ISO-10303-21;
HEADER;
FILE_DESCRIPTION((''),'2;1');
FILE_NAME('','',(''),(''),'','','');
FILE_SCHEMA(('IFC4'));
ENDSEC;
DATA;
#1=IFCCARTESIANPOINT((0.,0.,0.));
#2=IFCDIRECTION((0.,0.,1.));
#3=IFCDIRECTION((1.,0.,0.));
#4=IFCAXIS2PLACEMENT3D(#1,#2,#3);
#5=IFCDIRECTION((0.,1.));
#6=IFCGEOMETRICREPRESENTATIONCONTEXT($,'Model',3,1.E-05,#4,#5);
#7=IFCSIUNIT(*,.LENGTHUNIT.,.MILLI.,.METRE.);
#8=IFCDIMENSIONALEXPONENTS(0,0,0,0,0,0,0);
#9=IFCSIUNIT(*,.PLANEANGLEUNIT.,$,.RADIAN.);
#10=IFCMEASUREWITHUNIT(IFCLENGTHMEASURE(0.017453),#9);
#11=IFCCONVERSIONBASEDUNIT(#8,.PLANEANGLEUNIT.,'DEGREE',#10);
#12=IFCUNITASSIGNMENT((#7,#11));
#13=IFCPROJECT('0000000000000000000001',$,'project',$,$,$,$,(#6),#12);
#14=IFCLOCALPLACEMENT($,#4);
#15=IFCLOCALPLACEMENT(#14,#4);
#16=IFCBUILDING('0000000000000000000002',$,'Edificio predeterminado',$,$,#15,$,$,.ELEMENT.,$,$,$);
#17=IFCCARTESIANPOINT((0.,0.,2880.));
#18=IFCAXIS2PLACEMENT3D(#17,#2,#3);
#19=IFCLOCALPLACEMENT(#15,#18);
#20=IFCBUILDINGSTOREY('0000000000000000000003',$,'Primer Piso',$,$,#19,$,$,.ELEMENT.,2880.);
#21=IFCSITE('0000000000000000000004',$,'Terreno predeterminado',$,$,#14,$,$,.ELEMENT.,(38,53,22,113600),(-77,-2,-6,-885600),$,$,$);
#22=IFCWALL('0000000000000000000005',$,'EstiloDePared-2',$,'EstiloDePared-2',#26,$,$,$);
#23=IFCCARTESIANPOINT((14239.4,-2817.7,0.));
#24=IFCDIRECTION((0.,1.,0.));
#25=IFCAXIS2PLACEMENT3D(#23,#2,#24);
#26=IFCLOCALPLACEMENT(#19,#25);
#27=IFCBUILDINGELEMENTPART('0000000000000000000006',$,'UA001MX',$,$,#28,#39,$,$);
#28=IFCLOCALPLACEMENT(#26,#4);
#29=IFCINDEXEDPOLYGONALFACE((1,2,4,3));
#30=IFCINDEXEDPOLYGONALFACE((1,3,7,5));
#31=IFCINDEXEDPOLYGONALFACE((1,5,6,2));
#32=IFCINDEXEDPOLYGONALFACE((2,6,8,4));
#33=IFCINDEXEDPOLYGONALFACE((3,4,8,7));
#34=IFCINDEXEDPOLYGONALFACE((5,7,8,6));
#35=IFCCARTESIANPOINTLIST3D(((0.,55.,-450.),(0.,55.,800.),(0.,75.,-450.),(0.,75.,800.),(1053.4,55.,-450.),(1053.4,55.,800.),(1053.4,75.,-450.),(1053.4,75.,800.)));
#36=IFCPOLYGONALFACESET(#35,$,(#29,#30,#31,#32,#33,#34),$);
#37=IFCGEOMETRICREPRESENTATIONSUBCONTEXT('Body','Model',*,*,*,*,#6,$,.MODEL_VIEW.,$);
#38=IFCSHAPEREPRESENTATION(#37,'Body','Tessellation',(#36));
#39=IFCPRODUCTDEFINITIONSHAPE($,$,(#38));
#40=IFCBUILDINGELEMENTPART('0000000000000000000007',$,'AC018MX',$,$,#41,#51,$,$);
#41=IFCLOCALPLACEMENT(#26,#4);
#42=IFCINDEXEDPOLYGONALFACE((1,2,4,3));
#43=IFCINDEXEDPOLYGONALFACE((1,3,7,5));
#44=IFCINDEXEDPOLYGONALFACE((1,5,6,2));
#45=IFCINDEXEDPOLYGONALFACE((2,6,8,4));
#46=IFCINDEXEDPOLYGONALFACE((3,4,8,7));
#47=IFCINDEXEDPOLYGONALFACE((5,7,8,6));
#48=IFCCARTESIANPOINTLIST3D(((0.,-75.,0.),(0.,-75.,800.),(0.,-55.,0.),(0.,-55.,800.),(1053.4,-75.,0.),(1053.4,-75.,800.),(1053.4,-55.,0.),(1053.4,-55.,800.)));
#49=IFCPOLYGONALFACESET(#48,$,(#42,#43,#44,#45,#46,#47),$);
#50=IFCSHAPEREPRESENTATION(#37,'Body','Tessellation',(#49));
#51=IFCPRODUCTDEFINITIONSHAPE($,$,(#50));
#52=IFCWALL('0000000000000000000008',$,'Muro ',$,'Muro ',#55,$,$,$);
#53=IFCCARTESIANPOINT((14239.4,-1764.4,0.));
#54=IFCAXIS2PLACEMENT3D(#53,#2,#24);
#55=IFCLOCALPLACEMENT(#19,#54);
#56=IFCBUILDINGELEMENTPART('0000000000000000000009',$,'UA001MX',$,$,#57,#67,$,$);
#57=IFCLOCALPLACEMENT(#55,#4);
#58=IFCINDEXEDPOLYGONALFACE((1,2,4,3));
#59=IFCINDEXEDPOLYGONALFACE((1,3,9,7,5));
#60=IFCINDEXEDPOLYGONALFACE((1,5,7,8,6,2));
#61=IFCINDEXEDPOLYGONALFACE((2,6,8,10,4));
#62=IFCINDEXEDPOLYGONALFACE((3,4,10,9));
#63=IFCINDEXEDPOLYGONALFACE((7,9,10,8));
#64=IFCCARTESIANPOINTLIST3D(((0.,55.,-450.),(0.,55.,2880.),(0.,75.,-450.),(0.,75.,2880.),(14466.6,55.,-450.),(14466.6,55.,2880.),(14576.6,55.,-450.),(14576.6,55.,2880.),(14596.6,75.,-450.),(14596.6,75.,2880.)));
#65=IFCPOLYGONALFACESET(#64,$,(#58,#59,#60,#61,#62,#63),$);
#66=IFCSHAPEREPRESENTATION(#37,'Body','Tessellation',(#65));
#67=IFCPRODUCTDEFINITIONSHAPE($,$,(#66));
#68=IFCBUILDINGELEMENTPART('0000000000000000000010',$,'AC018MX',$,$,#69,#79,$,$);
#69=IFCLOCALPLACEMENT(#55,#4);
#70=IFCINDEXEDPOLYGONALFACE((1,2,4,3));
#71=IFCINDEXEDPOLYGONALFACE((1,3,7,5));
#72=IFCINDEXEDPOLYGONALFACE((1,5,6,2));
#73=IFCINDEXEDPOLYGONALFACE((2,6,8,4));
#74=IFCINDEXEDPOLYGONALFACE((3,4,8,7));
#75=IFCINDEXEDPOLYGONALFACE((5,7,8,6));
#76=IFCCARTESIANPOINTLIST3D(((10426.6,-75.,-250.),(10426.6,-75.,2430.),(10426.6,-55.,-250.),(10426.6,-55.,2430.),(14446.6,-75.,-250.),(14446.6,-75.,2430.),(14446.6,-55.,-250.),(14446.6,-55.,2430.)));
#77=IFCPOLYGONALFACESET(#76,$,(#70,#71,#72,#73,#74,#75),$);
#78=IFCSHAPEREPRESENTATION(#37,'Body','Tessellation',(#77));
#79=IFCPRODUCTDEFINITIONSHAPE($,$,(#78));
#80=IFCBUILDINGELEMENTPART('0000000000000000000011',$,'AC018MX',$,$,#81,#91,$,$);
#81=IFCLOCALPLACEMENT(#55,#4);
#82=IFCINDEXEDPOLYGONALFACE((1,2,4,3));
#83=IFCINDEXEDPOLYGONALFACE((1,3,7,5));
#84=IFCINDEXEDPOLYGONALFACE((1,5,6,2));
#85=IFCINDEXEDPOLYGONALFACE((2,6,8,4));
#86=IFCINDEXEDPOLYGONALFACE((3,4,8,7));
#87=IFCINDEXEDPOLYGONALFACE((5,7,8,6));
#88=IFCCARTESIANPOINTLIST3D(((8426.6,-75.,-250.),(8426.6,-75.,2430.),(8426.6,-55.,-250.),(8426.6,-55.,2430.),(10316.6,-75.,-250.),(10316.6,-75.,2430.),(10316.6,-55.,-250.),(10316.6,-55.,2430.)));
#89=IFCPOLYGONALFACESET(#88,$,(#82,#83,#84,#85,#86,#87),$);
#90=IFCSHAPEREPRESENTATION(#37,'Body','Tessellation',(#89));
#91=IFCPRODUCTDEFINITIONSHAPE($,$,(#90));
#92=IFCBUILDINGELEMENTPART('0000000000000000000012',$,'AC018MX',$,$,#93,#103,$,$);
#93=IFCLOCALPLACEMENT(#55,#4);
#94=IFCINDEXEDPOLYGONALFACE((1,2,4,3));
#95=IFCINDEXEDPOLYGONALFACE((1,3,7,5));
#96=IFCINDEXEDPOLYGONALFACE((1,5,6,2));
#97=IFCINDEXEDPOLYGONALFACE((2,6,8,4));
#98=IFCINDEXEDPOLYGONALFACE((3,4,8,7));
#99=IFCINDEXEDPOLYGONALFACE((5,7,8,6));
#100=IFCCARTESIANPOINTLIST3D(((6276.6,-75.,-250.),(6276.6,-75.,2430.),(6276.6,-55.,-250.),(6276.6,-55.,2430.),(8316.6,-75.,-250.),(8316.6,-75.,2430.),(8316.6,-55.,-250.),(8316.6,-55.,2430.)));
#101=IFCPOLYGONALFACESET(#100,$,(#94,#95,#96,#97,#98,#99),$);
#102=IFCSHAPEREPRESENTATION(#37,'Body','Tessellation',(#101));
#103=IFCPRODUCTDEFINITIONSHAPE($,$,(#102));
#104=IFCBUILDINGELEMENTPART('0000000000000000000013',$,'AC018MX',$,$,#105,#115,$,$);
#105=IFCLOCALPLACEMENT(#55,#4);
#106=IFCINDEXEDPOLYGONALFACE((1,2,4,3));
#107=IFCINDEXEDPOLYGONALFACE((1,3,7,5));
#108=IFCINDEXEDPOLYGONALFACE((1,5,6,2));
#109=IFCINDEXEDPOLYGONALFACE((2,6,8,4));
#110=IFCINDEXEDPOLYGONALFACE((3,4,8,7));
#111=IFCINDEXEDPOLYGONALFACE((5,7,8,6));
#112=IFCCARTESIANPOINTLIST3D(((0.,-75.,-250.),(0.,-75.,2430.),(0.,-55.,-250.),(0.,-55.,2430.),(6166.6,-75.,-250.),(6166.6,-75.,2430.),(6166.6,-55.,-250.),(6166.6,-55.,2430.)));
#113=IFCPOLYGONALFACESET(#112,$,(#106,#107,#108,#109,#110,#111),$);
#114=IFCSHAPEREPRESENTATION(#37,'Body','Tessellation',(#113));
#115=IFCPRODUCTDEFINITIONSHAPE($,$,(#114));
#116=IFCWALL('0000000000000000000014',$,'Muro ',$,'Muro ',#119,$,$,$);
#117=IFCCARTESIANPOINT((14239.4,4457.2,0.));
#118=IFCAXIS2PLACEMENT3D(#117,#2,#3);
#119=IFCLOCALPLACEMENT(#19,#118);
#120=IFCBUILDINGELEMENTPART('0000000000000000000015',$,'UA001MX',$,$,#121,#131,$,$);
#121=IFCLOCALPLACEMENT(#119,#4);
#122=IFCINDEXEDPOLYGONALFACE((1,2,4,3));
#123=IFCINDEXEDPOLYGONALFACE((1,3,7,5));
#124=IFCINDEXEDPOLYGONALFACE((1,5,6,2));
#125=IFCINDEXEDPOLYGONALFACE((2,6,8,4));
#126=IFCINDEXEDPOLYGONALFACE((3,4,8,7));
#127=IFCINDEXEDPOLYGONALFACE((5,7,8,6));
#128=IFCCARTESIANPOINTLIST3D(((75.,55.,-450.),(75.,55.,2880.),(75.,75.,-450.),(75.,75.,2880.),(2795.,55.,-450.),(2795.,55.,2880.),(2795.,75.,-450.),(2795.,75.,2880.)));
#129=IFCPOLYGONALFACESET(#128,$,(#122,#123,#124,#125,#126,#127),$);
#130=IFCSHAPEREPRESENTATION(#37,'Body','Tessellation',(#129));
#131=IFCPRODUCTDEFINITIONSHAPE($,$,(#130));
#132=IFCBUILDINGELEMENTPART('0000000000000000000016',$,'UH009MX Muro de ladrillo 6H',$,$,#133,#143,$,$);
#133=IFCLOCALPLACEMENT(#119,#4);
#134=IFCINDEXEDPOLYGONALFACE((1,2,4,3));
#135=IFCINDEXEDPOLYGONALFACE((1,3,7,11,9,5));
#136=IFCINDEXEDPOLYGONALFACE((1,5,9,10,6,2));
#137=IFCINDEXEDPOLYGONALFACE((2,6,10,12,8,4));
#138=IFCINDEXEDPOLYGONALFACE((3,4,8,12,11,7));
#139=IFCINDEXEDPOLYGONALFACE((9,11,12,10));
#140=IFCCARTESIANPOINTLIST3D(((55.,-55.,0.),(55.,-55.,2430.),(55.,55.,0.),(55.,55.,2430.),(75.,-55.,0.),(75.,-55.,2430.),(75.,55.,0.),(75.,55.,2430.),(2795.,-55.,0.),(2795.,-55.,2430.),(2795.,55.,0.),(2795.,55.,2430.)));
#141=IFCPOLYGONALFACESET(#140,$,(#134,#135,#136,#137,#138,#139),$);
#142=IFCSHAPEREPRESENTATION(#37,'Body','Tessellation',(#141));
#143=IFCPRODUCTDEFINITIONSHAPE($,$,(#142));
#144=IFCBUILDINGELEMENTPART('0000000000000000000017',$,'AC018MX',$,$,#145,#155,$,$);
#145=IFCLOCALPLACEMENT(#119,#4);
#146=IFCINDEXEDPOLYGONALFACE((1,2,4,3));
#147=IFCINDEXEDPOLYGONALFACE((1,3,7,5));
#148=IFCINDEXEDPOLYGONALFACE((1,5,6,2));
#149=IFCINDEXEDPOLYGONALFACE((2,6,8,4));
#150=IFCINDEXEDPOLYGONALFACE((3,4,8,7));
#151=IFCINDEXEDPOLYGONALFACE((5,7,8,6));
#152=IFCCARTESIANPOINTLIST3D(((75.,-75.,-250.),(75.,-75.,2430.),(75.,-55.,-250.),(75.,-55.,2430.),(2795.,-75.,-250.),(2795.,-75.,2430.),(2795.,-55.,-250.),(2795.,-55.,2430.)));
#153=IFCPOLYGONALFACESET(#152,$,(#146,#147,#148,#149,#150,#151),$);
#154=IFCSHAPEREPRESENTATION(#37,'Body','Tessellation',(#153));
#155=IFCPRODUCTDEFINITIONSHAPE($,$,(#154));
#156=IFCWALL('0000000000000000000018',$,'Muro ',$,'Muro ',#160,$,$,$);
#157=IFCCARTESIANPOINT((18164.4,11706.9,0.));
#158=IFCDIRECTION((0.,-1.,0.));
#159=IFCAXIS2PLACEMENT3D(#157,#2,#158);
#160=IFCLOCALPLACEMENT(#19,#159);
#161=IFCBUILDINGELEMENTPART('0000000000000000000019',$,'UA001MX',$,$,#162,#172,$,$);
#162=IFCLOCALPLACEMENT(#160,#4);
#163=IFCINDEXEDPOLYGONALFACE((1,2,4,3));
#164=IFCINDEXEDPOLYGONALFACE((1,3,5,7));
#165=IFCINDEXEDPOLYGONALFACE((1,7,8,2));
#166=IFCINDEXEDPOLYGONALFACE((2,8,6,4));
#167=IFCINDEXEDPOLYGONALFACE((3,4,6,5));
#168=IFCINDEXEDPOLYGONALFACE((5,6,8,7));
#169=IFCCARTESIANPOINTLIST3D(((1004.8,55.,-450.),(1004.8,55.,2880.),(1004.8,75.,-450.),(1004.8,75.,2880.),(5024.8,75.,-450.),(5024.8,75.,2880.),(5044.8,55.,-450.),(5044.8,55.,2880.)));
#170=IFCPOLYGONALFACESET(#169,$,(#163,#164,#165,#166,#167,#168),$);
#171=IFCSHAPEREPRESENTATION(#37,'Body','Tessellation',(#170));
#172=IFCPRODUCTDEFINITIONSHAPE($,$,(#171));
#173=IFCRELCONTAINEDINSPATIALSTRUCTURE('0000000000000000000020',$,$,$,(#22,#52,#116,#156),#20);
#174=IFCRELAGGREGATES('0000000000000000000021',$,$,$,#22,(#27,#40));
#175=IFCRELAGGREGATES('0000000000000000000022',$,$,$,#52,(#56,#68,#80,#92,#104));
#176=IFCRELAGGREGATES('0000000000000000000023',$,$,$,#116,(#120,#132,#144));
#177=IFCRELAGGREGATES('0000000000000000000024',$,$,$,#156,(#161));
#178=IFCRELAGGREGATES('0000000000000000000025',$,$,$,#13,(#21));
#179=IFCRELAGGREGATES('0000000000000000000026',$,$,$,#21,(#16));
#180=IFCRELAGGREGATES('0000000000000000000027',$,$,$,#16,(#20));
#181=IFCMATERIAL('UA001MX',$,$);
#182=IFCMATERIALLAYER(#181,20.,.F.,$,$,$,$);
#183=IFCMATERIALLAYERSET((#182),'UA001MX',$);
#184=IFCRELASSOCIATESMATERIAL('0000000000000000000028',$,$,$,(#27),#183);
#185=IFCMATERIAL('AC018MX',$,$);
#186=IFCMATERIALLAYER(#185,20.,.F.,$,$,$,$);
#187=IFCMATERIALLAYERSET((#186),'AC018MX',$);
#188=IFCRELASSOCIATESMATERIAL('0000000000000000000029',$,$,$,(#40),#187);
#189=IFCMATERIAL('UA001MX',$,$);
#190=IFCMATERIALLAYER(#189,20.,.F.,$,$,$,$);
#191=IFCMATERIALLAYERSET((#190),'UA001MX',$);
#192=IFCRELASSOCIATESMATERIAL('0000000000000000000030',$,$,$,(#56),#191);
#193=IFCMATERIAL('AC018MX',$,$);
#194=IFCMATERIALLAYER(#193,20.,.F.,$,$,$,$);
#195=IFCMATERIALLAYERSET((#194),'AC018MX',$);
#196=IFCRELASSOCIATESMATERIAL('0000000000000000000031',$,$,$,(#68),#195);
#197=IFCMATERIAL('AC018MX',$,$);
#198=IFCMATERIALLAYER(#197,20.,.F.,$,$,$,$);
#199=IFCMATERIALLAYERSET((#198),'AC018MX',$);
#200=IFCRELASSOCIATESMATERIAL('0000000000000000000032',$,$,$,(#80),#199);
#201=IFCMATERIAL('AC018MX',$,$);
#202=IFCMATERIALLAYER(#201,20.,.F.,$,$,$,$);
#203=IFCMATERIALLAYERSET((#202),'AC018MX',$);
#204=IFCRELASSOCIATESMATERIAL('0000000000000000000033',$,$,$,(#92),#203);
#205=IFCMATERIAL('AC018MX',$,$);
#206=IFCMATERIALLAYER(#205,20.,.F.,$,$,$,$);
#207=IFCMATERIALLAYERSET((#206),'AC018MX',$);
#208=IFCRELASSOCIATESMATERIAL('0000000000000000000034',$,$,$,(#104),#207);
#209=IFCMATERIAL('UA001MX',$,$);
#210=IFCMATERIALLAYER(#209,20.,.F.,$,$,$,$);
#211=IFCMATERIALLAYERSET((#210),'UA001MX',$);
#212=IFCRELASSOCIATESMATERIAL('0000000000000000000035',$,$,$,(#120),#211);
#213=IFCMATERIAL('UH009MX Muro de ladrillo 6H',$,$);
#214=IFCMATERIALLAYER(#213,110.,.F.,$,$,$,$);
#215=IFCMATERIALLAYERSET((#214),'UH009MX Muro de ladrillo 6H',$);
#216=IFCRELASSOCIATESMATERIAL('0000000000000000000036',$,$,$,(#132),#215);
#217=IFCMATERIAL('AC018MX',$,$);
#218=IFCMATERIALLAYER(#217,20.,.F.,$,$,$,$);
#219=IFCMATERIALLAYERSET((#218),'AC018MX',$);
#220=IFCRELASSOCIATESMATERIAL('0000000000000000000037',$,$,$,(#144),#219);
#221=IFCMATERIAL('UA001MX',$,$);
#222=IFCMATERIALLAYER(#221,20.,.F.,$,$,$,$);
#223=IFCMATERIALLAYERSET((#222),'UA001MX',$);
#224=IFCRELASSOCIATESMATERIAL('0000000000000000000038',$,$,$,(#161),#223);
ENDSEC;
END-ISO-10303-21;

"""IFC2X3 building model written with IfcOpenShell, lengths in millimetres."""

from ifc_helpers import new_model, entity, si_unit, converted_unit, direction, frame, origin_with_axes, place, context, subcontext, project, spatial, polyline, outline, extrude, material, layer, layer_set, layer_usage, element, aggregate, save


model = new_model("IFC2X3")

# Units and contexts
model_context = context("Model", 3, precision=1e-05, world=origin_with_axes(), true_north=direction((0.0, 1.0)))
body_context = subcontext(model_context, "Body", "Model", "MODEL_VIEW")
ifc_project = project(units=[si_unit("LENGTHUNIT", "METRE", prefix="MILLI"), converted_unit("PLANEANGLEUNIT", "DEGREE", entity("IfcLengthMeasure", 0.017453), si_unit("PLANEANGLEUNIT", "RADIAN"), dimensions=[0, 0, 0, 0, 0, 0, 0])], contexts=[model_context])

# Site, building, storey
site_placement = place(None, origin_with_axes())
site = spatial("IfcSite", under=ifc_project, at=site_placement, Name="Terreno predeterminado", CompositionType="ELEMENT", RefLatitude=(38, 53, 22, 113600), RefLongitude=(-77, -2, -6, -885600))
building_placement = place(site_placement, origin_with_axes())
building = spatial("IfcBuilding", under=site, at=building_placement, Name="Edificio predeterminado", CompositionType="ELEMENT")
storey_placement = place(building_placement, frame((0.0, 0.0, 2880.0), z_axis=(0.0, 0.0, 1.0), x_axis=(1.0, 0.0, 0.0)))
storey = spatial("IfcBuildingStorey", under=building, at=storey_placement, Name="Primer Piso", CompositionType="ELEMENT", Elevation=2880.0)

# Walls, building element parts
wall_1_placement = place(storey_placement, frame((14239.4, -2817.7, 0.0), z_axis=(0.0, 0.0, 1.0), x_axis=(0.0, 1.0, 0.0)))
wall_1 = element("IfcWall", 1, at=wall_1_placement, inside=storey, Name="EstiloDePared-2", ObjectType="EstiloDePared-2")
ifc_material_1 = material(Name="UA001MX")
ifc_layer_1 = layer(ifc_material_1, 20.0, ventilated=False)
ifc_layer_set_1 = layer_set([ifc_layer_1], Name="UA001MX")
ifc_layer_usage_1 = layer_usage(ifc_layer_set_1, "AXIS2", "NEGATIVE", -75.0)
building_element_part_1_placement = place(wall_1_placement, origin_with_axes())
building_element_part_1 = element("IfcBuildingElementPart", 2, at=building_element_part_1_placement, material=ifc_layer_usage_1, Name="UA001MX", context=body_context, shape_type="SweptSolid", body=[
    extrude(outline(polyline([(1053.4, 75.0), (1053.4, 55.0), (0.0, 55.0), (0.0, 75.0), (1053.4, 75.0)])), frame((0.0, 0.0, -450.0), z_axis=(0.0, 0.0, 1.0), x_axis=(1.0, 0.0, 0.0)), (0.0, 0.0, 1.0), 1250.0),
])
ifc_material_2 = material(Name="AC018MX")
ifc_layer_2 = layer(ifc_material_2, 20.0, ventilated=False)
ifc_layer_set_2 = layer_set([ifc_layer_2], Name="AC018MX")
ifc_layer_usage_2 = layer_usage(ifc_layer_set_2, "AXIS2", "NEGATIVE", 55.0)
building_element_part_2_placement = place(wall_1_placement, origin_with_axes())
building_element_part_2 = element("IfcBuildingElementPart", 3, at=building_element_part_2_placement, material=ifc_layer_usage_2, Name="AC018MX", context=body_context, shape_type="SweptSolid", body=[
    extrude(outline(polyline([(1053.4, -55.0), (1053.4, -75.0), (0.0, -75.0), (0.0, -55.0), (1053.4, -55.0)])), origin_with_axes(), (0.0, 0.0, 1.0), 800.0),
])
aggregate(wall_1, [building_element_part_1, building_element_part_2])
wall_2_placement = place(storey_placement, frame((14239.4, -1764.4, 0.0), z_axis=(0.0, 0.0, 1.0), x_axis=(0.0, 1.0, 0.0)))
wall_2 = element("IfcWall", 4, at=wall_2_placement, inside=storey, Name="Muro ", ObjectType="Muro ")
ifc_material_3 = material(Name="UA001MX")
ifc_layer_3 = layer(ifc_material_3, 20.0, ventilated=False)
ifc_layer_set_3 = layer_set([ifc_layer_3], Name="UA001MX")
ifc_layer_usage_3 = layer_usage(ifc_layer_set_3, "AXIS2", "NEGATIVE", -75.0)
building_element_part_3_placement = place(wall_2_placement, origin_with_axes())
building_element_part_3 = element("IfcBuildingElementPart", 5, at=building_element_part_3_placement, material=ifc_layer_usage_3, Name="UA001MX", context=body_context, shape_type="SweptSolid", body=[
    extrude(outline(polyline([(14596.6, 75.0), (14576.6, 55.0), (14466.6, 55.0), (0.0, 55.0), (0.0, 75.0), (14596.6, 75.0)])), frame((0.0, 0.0, -450.0), z_axis=(0.0, 0.0, 1.0), x_axis=(1.0, 0.0, 0.0)), (0.0, 0.0, 1.0), 3330.0),
])
ifc_material_4 = material(Name="AC018MX")
ifc_layer_4 = layer(ifc_material_4, 20.0, ventilated=False)
ifc_layer_set_4 = layer_set([ifc_layer_4], Name="AC018MX")
ifc_layer_usage_4 = layer_usage(ifc_layer_set_4, "AXIS2", "NEGATIVE", 55.0)
building_element_part_4_placement = place(wall_2_placement, origin_with_axes())
building_element_part_4 = element("IfcBuildingElementPart", 6, at=building_element_part_4_placement, material=ifc_layer_usage_4, Name="AC018MX", context=body_context, shape_type="SweptSolid", body=[
    extrude(outline(polyline([(14446.6, -55.0), (14446.6, -75.0), (10426.6, -75.0), (10426.6, -55.0), (14446.6, -55.0)])), frame((0.0, 0.0, -250.0), z_axis=(0.0, 0.0, 1.0), x_axis=(1.0, 0.0, 0.0)), (0.0, 0.0, 1.0), 2680.0),
])
ifc_material_5 = material(Name="AC018MX")
ifc_layer_5 = layer(ifc_material_5, 20.0, ventilated=False)
ifc_layer_set_5 = layer_set([ifc_layer_5], Name="AC018MX")
ifc_layer_usage_5 = layer_usage(ifc_layer_set_5, "AXIS2", "NEGATIVE", 55.0)
building_element_part_5_placement = place(wall_2_placement, origin_with_axes())
building_element_part_5 = element("IfcBuildingElementPart", 7, at=building_element_part_5_placement, material=ifc_layer_usage_5, Name="AC018MX", context=body_context, shape_type="SweptSolid", body=[
    extrude(outline(polyline([(10316.6, -55.0), (10316.6, -75.0), (8426.6, -75.0), (8426.6, -55.0), (10316.6, -55.0)])), frame((0.0, 0.0, -250.0), z_axis=(0.0, 0.0, 1.0), x_axis=(1.0, 0.0, 0.0)), (0.0, 0.0, 1.0), 2680.0),
])
ifc_material_6 = material(Name="AC018MX")
ifc_layer_6 = layer(ifc_material_6, 20.0, ventilated=False)
ifc_layer_set_6 = layer_set([ifc_layer_6], Name="AC018MX")
ifc_layer_usage_6 = layer_usage(ifc_layer_set_6, "AXIS2", "NEGATIVE", 55.0)
building_element_part_6_placement = place(wall_2_placement, origin_with_axes())
building_element_part_6 = element("IfcBuildingElementPart", 8, at=building_element_part_6_placement, material=ifc_layer_usage_6, Name="AC018MX", context=body_context, shape_type="SweptSolid", body=[
    extrude(outline(polyline([(8316.6, -55.0), (8316.6, -75.0), (6276.6, -75.0), (6276.6, -55.0), (8316.6, -55.0)])), frame((0.0, 0.0, -250.0), z_axis=(0.0, 0.0, 1.0), x_axis=(1.0, 0.0, 0.0)), (0.0, 0.0, 1.0), 2680.0),
])
ifc_material_7 = material(Name="AC018MX")
ifc_layer_7 = layer(ifc_material_7, 20.0, ventilated=False)
ifc_layer_set_7 = layer_set([ifc_layer_7], Name="AC018MX")
ifc_layer_usage_7 = layer_usage(ifc_layer_set_7, "AXIS2", "NEGATIVE", 55.0)
building_element_part_7_placement = place(wall_2_placement, origin_with_axes())
building_element_part_7 = element("IfcBuildingElementPart", 9, at=building_element_part_7_placement, material=ifc_layer_usage_7, Name="AC018MX", context=body_context, shape_type="SweptSolid", body=[
    extrude(outline(polyline([(6166.6, -55.0), (6166.6, -75.0), (0.0, -75.0), (0.0, -55.0), (6166.6, -55.0)])), frame((0.0, 0.0, -250.0), z_axis=(0.0, 0.0, 1.0), x_axis=(1.0, 0.0, 0.0)), (0.0, 0.0, 1.0), 2680.0),
])
aggregate(wall_2, [building_element_part_3, building_element_part_4, building_element_part_5, building_element_part_6, building_element_part_7])
wall_3_placement = place(storey_placement, frame((14239.4, 4457.2, 0.0), z_axis=(0.0, 0.0, 1.0), x_axis=(1.0, 0.0, 0.0)))
wall_3 = element("IfcWall", 10, at=wall_3_placement, inside=storey, Name="Muro ", ObjectType="Muro ")
ifc_material_8 = material(Name="UA001MX")
ifc_layer_8 = layer(ifc_material_8, 20.0, ventilated=False)
ifc_layer_set_8 = layer_set([ifc_layer_8], Name="UA001MX")
ifc_layer_usage_8 = layer_usage(ifc_layer_set_8, "AXIS2", "NEGATIVE", -75.0)
building_element_part_8_placement = place(wall_3_placement, origin_with_axes())
building_element_part_8 = element("IfcBuildingElementPart", 11, at=building_element_part_8_placement, material=ifc_layer_usage_8, Name="UA001MX", context=body_context, shape_type="SweptSolid", body=[
    extrude(outline(polyline([(2795.0, 75.0), (2795.0, 55.0), (75.0, 55.0), (75.0, 75.0), (2795.0, 75.0)])), frame((0.0, 0.0, -450.0), z_axis=(0.0, 0.0, 1.0), x_axis=(1.0, 0.0, 0.0)), (0.0, 0.0, 1.0), 3330.0),
])
ifc_material_9 = material(Name="UH009MX Muro de ladrillo 6H")
ifc_layer_9 = layer(ifc_material_9, 110.0, ventilated=False)
ifc_layer_set_9 = layer_set([ifc_layer_9], Name="UH009MX Muro de ladrillo 6H")
ifc_layer_usage_9 = layer_usage(ifc_layer_set_9, "AXIS2", "NEGATIVE", -55.0)
building_element_part_9_placement = place(wall_3_placement, origin_with_axes())
building_element_part_9 = element("IfcBuildingElementPart", 12, at=building_element_part_9_placement, material=ifc_layer_usage_9, Name="UH009MX Muro de ladrillo 6H", context=body_context, shape_type="SweptSolid", body=[
    extrude(outline(polyline([(2795.0, 55.0), (2795.0, -55.0), (75.0, -55.0), (55.0, -55.0), (55.0, 55.0), (75.0, 55.0), (2795.0, 55.0)])), origin_with_axes(), (0.0, 0.0, 1.0), 2430.0),
])
ifc_material_10 = material(Name="AC018MX")
ifc_layer_10 = layer(ifc_material_10, 20.0, ventilated=False)
ifc_layer_set_10 = layer_set([ifc_layer_10], Name="AC018MX")
ifc_layer_usage_10 = layer_usage(ifc_layer_set_10, "AXIS2", "NEGATIVE", 55.0)
building_element_part_10_placement = place(wall_3_placement, origin_with_axes())
building_element_part_10 = element("IfcBuildingElementPart", 13, at=building_element_part_10_placement, material=ifc_layer_usage_10, Name="AC018MX", context=body_context, shape_type="SweptSolid", body=[
    extrude(outline(polyline([(75.0, -55.0), (2795.0, -55.0), (2795.0, -75.0), (75.0, -75.0), (75.0, -55.0)])), frame((0.0, 0.0, -250.0), z_axis=(0.0, 0.0, 1.0), x_axis=(1.0, 0.0, 0.0)), (0.0, 0.0, 1.0), 2680.0),
])
aggregate(wall_3, [building_element_part_8, building_element_part_9, building_element_part_10])
wall_4_placement = place(storey_placement, frame((18164.4, 11706.9, 0.0), z_axis=(0.0, 0.0, 1.0), x_axis=(0.0, -1.0, 0.0)))
wall_4 = element("IfcWall", 14, at=wall_4_placement, inside=storey, Name="Muro ", ObjectType="Muro ")
ifc_material_11 = material(Name="UA001MX")
ifc_layer_11 = layer(ifc_material_11, 20.0, ventilated=False)
ifc_layer_set_11 = layer_set([ifc_layer_11], Name="UA001MX")
ifc_layer_usage_11 = layer_usage(ifc_layer_set_11, "AXIS2", "NEGATIVE", -75.0)
building_element_part_11_placement = place(wall_4_placement, origin_with_axes())
building_element_part_11 = element("IfcBuildingElementPart", 15, at=building_element_part_11_placement, material=ifc_layer_usage_11, Name="UA001MX", context=body_context, shape_type="SweptSolid", body=[
    extrude(outline(polyline([(5024.8, 75.0), (5044.8, 55.0), (1004.8, 55.0), (1004.8, 75.0), (5024.8, 75.0)])), frame((0.0, 0.0, -450.0), z_axis=(0.0, 0.0, 1.0), x_axis=(1.0, 0.0, 0.0)), (0.0, 0.0, 1.0), 3330.0),
])
aggregate(wall_4, [building_element_part_11])

save(model, "model.ifc")
